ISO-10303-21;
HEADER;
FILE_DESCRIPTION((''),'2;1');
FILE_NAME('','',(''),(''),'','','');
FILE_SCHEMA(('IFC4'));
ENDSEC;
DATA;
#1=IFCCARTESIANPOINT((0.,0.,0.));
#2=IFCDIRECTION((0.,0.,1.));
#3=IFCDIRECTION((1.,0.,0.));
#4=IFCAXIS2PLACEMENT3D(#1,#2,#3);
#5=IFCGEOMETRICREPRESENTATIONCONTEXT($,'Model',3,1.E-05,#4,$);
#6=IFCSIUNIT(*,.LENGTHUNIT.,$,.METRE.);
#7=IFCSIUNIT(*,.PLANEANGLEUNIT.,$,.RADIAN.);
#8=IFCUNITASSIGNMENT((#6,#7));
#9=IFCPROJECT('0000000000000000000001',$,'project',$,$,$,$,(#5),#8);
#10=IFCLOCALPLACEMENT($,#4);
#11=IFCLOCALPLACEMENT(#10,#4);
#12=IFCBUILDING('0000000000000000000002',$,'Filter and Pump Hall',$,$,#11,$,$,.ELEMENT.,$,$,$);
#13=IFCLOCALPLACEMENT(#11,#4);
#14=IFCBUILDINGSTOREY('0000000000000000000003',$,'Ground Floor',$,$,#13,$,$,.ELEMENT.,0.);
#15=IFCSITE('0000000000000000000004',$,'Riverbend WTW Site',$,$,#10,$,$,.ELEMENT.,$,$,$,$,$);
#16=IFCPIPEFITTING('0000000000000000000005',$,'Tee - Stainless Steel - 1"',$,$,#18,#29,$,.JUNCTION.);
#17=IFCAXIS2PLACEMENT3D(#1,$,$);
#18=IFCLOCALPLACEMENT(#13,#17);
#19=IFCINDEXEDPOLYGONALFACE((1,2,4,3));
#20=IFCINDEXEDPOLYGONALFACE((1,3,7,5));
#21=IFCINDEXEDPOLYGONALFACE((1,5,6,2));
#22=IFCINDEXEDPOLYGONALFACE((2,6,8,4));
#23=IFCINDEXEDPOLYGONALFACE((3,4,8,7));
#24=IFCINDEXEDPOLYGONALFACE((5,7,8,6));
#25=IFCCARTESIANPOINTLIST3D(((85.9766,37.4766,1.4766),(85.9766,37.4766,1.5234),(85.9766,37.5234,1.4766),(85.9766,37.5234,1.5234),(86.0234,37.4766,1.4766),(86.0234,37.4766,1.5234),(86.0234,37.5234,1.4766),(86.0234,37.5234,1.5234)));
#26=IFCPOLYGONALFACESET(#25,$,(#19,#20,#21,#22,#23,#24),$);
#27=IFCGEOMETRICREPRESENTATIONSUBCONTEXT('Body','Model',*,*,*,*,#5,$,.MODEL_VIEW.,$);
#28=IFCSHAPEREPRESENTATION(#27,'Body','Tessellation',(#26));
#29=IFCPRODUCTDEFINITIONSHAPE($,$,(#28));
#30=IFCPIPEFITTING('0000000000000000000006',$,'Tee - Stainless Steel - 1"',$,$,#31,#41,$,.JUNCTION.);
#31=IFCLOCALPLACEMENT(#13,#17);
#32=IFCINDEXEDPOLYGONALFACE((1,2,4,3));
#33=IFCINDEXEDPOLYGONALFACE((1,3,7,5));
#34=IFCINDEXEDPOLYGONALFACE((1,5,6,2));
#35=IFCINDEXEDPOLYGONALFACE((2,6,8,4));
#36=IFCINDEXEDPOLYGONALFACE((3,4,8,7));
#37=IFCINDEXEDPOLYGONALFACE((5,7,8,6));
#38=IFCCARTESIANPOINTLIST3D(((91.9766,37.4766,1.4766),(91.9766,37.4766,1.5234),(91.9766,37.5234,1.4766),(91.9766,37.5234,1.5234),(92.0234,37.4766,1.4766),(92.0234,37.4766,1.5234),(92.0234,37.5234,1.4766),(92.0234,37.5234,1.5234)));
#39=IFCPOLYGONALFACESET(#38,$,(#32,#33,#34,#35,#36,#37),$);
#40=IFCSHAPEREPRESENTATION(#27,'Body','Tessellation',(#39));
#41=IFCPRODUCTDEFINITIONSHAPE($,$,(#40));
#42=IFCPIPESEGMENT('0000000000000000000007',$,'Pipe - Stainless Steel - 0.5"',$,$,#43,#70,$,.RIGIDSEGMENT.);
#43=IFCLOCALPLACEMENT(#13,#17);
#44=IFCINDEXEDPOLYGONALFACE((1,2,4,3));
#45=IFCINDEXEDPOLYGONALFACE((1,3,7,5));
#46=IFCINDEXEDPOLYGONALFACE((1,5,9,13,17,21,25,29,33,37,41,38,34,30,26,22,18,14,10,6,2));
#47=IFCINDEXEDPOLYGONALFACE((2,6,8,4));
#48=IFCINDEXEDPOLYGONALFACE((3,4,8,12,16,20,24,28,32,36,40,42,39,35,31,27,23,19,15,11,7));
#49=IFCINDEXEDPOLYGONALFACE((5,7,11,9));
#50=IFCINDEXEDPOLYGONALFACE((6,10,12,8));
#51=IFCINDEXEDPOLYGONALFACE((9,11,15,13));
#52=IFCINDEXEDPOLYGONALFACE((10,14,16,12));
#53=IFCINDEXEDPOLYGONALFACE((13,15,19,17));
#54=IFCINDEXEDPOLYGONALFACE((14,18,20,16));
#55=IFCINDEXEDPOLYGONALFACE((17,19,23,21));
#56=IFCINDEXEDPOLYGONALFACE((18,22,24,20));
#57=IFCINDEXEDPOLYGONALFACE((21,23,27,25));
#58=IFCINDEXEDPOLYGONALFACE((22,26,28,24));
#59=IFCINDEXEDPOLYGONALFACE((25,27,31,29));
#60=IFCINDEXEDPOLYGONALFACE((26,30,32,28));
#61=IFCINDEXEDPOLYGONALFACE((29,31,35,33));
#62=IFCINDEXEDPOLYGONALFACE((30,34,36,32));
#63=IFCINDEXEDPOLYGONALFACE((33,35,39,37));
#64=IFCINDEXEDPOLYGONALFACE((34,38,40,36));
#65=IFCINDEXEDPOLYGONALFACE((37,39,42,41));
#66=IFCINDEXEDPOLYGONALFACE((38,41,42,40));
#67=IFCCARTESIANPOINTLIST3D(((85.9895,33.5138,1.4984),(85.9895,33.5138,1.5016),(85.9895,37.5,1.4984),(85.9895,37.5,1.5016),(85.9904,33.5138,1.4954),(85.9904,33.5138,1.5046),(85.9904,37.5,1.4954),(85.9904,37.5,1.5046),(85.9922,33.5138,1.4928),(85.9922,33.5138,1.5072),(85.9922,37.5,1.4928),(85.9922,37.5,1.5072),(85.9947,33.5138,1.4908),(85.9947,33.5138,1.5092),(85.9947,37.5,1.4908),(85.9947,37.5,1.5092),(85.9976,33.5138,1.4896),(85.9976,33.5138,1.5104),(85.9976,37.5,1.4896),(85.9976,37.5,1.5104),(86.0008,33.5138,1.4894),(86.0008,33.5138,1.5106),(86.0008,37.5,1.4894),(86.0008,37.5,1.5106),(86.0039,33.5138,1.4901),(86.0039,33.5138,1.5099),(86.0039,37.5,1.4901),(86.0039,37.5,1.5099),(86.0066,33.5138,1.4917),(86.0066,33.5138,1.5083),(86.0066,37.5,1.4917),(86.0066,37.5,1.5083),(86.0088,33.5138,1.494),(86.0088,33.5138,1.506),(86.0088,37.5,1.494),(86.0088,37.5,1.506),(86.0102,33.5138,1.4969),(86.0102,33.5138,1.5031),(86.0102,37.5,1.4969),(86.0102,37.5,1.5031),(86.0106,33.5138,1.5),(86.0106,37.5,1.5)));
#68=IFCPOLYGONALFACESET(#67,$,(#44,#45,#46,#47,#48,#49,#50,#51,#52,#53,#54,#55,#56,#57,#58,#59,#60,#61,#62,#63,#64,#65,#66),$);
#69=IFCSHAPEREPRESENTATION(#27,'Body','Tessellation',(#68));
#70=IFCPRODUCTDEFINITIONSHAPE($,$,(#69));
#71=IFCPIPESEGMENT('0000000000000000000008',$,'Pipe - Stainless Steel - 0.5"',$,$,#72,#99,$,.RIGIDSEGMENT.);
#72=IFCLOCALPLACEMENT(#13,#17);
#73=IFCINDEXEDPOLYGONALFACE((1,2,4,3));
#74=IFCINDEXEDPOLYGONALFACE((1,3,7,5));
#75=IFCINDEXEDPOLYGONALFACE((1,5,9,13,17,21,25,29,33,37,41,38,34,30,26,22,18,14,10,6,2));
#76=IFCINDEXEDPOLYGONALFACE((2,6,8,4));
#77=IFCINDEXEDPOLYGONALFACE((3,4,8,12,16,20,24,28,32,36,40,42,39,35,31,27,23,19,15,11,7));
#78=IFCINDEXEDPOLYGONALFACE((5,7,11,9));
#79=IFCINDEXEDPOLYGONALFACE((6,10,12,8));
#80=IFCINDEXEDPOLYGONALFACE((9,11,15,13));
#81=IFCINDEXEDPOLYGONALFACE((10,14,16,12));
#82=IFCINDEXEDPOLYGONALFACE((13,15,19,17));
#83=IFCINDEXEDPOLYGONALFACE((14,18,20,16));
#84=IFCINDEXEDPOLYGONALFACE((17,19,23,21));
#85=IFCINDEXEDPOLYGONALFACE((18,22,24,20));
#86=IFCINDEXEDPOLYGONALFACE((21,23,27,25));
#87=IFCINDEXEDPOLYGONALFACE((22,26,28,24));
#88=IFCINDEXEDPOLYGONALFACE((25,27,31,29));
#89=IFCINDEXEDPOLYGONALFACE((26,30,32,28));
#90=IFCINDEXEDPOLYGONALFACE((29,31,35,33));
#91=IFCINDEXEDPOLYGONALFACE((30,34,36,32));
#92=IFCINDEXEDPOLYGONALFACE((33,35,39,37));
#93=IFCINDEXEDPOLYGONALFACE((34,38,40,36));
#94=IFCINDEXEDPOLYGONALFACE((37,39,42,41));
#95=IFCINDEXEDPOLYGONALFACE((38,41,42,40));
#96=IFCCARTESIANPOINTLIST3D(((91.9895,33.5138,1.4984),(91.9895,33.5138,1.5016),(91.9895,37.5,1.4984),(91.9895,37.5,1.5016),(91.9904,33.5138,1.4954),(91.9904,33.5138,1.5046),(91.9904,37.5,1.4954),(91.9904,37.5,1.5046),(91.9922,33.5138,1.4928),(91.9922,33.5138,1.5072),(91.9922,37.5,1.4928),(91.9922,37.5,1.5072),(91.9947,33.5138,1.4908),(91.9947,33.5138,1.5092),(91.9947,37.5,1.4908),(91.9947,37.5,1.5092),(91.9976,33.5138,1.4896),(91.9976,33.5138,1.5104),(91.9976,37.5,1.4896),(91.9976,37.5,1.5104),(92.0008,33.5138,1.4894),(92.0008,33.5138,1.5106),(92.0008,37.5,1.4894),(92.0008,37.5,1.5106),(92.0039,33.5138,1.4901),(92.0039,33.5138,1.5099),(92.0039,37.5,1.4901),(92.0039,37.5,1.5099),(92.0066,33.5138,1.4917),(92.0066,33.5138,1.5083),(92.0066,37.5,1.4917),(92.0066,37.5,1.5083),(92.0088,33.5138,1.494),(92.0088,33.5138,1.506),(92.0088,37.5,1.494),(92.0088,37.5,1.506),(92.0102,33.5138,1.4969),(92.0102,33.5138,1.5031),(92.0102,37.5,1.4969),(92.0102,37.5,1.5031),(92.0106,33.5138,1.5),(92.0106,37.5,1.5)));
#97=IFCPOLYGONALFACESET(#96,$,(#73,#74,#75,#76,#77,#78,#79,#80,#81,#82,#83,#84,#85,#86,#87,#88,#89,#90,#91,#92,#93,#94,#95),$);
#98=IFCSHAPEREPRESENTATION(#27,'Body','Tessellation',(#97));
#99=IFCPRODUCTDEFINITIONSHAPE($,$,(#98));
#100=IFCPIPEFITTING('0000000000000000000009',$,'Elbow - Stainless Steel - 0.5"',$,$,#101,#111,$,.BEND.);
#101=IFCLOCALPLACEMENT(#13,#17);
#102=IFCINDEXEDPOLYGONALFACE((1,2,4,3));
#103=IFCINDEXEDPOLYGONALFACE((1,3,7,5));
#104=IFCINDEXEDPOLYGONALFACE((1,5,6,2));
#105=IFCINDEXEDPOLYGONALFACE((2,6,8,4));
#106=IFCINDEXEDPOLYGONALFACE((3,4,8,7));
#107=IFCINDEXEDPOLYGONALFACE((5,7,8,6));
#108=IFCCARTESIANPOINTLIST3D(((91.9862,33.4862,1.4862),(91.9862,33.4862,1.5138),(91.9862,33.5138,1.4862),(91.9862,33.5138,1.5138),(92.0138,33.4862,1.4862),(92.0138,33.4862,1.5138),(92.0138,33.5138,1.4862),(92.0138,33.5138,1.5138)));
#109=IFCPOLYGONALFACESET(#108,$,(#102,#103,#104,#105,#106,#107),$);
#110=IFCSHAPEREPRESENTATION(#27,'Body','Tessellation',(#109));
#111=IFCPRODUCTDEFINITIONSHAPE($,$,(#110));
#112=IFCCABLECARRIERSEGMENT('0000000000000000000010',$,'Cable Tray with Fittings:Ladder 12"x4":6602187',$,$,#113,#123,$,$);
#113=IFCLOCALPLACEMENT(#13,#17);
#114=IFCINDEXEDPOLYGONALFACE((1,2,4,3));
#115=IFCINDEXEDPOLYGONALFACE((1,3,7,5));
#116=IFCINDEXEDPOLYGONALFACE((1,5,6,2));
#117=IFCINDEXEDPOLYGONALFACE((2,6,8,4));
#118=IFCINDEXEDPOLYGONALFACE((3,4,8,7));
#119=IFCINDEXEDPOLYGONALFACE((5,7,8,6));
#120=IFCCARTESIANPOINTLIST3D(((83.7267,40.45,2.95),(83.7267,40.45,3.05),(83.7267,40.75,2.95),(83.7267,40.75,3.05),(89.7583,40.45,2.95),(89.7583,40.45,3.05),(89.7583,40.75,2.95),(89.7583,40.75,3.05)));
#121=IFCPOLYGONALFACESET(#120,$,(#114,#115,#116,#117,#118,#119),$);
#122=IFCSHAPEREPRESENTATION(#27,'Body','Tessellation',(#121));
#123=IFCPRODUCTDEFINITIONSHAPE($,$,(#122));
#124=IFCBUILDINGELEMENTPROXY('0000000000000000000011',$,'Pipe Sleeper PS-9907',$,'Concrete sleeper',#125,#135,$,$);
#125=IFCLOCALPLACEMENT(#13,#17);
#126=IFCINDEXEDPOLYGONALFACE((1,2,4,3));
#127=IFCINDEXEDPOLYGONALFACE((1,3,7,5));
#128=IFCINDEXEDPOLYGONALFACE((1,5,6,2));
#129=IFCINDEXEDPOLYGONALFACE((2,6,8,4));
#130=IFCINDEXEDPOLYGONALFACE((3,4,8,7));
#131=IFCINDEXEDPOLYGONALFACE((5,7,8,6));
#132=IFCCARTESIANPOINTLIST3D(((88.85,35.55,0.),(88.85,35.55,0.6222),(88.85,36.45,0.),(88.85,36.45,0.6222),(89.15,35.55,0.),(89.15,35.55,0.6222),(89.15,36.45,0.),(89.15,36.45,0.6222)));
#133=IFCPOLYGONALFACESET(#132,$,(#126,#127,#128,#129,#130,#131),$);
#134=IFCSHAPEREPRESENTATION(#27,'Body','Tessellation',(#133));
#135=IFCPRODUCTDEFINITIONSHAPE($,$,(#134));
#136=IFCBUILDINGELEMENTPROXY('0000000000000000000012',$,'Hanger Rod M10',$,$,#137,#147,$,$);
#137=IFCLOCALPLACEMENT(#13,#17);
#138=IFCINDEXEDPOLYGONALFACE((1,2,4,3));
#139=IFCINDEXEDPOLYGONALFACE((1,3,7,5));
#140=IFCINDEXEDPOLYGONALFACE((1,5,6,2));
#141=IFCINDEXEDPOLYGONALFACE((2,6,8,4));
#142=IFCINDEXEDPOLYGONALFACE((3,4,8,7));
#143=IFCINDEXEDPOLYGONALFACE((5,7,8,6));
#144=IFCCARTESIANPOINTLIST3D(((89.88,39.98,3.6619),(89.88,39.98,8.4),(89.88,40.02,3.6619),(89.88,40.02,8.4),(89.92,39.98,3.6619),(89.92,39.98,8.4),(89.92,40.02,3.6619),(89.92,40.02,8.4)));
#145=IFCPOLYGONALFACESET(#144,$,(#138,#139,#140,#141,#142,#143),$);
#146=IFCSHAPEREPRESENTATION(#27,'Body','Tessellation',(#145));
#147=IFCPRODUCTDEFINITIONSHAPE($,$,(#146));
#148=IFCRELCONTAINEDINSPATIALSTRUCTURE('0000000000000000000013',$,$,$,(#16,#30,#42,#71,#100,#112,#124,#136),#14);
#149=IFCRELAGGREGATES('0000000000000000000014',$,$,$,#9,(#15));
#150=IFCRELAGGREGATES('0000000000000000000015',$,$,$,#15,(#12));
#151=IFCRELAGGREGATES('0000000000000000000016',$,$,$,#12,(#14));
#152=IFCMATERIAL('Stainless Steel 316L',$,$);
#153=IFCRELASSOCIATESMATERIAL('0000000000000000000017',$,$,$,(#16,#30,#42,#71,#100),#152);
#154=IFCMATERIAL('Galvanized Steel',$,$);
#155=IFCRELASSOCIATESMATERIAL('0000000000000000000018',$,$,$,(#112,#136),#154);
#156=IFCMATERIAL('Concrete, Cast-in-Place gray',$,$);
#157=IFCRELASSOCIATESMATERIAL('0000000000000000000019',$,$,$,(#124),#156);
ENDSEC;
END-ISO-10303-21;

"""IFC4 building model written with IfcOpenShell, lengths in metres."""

from ifc_helpers import new_model, si_unit, frame, origin_with_axes, origin_2d, place, context, subcontext, project, spatial, rectangle, circle, extrude, material, element, save


model = new_model("IFC4")

# Units and contexts
model_context = context("Model", 3, precision=1e-05, world=origin_with_axes())
body_context = subcontext(model_context, "Body", "Model", "MODEL_VIEW")
ifc_project = project(units=[si_unit("LENGTHUNIT", "METRE"), si_unit("PLANEANGLEUNIT", "RADIAN")], contexts=[model_context])

# Site, building, storey
site_placement = place(None, origin_with_axes())
site = spatial("IfcSite", under=ifc_project, at=site_placement, Name="Riverbend WTW Site", CompositionType="ELEMENT")
building_placement = place(site_placement, origin_with_axes())
building = spatial("IfcBuilding", under=site, at=building_placement, Name="Filter and Pump Hall", CompositionType="ELEMENT")
storey_placement = place(building_placement, origin_with_axes())
storey = spatial("IfcBuildingStorey", under=building, at=storey_placement, Name="Ground Floor", CompositionType="ELEMENT", Elevation=0.0)

# Shared definitions
ifc_material_1 = material(Name="Concrete, Cast-in-Place gray")

# Shared definitions
ifc_material_2 = material(Name="Galvanized Steel")

# Shared definitions
ifc_material_3 = material(Name="Stainless Steel 316L")

# Pipe fittings
for number, where, z_axis, x_axis, name in (
    (1, (86.0, 37.5, 1.5), (0.0, 0.0, 1.0), (1.0, 0.0, 0.0), "Tee - Stainless Steel - 1\""),
    (2, (92.0, 37.5, 1.5), (0.0, 0.0, 1.0), (1.0, 0.0, 0.0), "Tee - Stainless Steel - 1\""),
):
    element("IfcPipeFitting", number, at=place(None, frame(where, z_axis=z_axis, x_axis=x_axis)), inside=storey, material=ifc_material_3, Name=name, PredefinedType="JUNCTION", context=body_context, shape_type="SweptSolid", body=[
        extrude(rectangle(XDim=0.0468, YDim=0.0468, at=origin_2d()), frame((0.0, 0.0, -0.0234), z_axis=(0.0, 0.0, 1.0), x_axis=(1.0, 0.0, 0.0)), (0.0, 0.0, 1.0), 0.0468),
    ])

# Pipe segments
for number, where, z_axis, x_axis, name in (
    (3, (86.0, 37.5, 1.5), (0.0, 0.0, 1.0), (1.0, 0.0, 0.0), "Pipe - Stainless Steel - 0.5\""),
    (4, (92.0, 37.5, 1.5), (0.0, 0.0, 1.0), (1.0, 0.0, 0.0), "Pipe - Stainless Steel - 0.5\""),
):
    element("IfcPipeSegment", number, at=place(None, frame(where, z_axis=z_axis, x_axis=x_axis)), inside=storey, material=ifc_material_3, Name=name, PredefinedType="RIGIDSEGMENT", context=body_context, shape_type="SweptSolid", body=[
        extrude(circle(Radius=0.0106, at=origin_2d()), frame((0.0, 0.0, 0.0), z_axis=(0.0, -1.0, 0.0), x_axis=(1.0, 0.0, 0.0)), (0.0, 0.0, 1.0), 3.9862),
    ])

# Pipe fitting
pipe_fitting_1_placement = place(None, frame((92.0, 33.5, 1.5), z_axis=(0.0, 0.0, 1.0), x_axis=(1.0, 0.0, 0.0)))
element("IfcPipeFitting", 5, at=pipe_fitting_1_placement, inside=storey, material=ifc_material_3, Name="Elbow - Stainless Steel - 0.5\"", PredefinedType="BEND", context=body_context, shape_type="SweptSolid", body=[
    extrude(rectangle(XDim=0.0277, YDim=0.0277, at=origin_2d()), frame((0.0, 0.0, -0.0138), z_axis=(0.0, 0.0, 1.0), x_axis=(1.0, 0.0, 0.0)), (0.0, 0.0, 1.0), 0.0277),
])

# Cable carrier segment
cable_carrier_segment_placement = place(None, frame((86.7425, 40.6, 3.0), z_axis=(0.0, 0.0, 1.0), x_axis=(1.0, 0.0, 0.0)))
element("IfcCableCarrierSegment", 6, at=cable_carrier_segment_placement, inside=storey, material=ifc_material_2, Name="Cable Tray with Fittings:Ladder 12\"x4\":6602187", context=body_context, shape_type="SweptSolid", body=[
    extrude(rectangle(XDim=6.0317, YDim=0.3, at=origin_2d()), frame((0.0, 0.0, -0.05), z_axis=(0.0, 0.0, 1.0), x_axis=(1.0, 0.0, 0.0)), (0.0, 0.0, 1.0), 0.1),
])

# Building element proxies
proxy_1_placement = place(None, frame((89.0, 36.0, 0.3111), z_axis=(0.0, 0.0, 1.0), x_axis=(1.0, 0.0, 0.0)))
element("IfcBuildingElementProxy", 7, at=proxy_1_placement, inside=storey, material=ifc_material_1, Name="Pipe Sleeper PS-9907", ObjectType="Concrete sleeper", context=body_context, shape_type="SweptSolid", body=[
    extrude(rectangle(XDim=0.3, YDim=0.9, at=origin_2d()), frame((0.0, 0.0, -0.3111), z_axis=(0.0, 0.0, 1.0), x_axis=(1.0, 0.0, 0.0)), (0.0, 0.0, 1.0), 0.6222),
])
proxy_2_placement = place(None, frame((89.9, 40.0, 6.031), z_axis=(0.0, 0.0, 1.0), x_axis=(1.0, 0.0, 0.0)))
element("IfcBuildingElementProxy", 8, at=proxy_2_placement, inside=storey, material=ifc_material_2, Name="Hanger Rod M10", context=body_context, shape_type="SweptSolid", body=[
    extrude(rectangle(XDim=0.04, YDim=0.04, at=origin_2d()), frame((0.0, 0.0, -2.3691), z_axis=(0.0, 0.0, 1.0), x_axis=(1.0, 0.0, 0.0)), (0.0, 0.0, 1.0), 4.7381),
])

save(model, "model.ifc")
